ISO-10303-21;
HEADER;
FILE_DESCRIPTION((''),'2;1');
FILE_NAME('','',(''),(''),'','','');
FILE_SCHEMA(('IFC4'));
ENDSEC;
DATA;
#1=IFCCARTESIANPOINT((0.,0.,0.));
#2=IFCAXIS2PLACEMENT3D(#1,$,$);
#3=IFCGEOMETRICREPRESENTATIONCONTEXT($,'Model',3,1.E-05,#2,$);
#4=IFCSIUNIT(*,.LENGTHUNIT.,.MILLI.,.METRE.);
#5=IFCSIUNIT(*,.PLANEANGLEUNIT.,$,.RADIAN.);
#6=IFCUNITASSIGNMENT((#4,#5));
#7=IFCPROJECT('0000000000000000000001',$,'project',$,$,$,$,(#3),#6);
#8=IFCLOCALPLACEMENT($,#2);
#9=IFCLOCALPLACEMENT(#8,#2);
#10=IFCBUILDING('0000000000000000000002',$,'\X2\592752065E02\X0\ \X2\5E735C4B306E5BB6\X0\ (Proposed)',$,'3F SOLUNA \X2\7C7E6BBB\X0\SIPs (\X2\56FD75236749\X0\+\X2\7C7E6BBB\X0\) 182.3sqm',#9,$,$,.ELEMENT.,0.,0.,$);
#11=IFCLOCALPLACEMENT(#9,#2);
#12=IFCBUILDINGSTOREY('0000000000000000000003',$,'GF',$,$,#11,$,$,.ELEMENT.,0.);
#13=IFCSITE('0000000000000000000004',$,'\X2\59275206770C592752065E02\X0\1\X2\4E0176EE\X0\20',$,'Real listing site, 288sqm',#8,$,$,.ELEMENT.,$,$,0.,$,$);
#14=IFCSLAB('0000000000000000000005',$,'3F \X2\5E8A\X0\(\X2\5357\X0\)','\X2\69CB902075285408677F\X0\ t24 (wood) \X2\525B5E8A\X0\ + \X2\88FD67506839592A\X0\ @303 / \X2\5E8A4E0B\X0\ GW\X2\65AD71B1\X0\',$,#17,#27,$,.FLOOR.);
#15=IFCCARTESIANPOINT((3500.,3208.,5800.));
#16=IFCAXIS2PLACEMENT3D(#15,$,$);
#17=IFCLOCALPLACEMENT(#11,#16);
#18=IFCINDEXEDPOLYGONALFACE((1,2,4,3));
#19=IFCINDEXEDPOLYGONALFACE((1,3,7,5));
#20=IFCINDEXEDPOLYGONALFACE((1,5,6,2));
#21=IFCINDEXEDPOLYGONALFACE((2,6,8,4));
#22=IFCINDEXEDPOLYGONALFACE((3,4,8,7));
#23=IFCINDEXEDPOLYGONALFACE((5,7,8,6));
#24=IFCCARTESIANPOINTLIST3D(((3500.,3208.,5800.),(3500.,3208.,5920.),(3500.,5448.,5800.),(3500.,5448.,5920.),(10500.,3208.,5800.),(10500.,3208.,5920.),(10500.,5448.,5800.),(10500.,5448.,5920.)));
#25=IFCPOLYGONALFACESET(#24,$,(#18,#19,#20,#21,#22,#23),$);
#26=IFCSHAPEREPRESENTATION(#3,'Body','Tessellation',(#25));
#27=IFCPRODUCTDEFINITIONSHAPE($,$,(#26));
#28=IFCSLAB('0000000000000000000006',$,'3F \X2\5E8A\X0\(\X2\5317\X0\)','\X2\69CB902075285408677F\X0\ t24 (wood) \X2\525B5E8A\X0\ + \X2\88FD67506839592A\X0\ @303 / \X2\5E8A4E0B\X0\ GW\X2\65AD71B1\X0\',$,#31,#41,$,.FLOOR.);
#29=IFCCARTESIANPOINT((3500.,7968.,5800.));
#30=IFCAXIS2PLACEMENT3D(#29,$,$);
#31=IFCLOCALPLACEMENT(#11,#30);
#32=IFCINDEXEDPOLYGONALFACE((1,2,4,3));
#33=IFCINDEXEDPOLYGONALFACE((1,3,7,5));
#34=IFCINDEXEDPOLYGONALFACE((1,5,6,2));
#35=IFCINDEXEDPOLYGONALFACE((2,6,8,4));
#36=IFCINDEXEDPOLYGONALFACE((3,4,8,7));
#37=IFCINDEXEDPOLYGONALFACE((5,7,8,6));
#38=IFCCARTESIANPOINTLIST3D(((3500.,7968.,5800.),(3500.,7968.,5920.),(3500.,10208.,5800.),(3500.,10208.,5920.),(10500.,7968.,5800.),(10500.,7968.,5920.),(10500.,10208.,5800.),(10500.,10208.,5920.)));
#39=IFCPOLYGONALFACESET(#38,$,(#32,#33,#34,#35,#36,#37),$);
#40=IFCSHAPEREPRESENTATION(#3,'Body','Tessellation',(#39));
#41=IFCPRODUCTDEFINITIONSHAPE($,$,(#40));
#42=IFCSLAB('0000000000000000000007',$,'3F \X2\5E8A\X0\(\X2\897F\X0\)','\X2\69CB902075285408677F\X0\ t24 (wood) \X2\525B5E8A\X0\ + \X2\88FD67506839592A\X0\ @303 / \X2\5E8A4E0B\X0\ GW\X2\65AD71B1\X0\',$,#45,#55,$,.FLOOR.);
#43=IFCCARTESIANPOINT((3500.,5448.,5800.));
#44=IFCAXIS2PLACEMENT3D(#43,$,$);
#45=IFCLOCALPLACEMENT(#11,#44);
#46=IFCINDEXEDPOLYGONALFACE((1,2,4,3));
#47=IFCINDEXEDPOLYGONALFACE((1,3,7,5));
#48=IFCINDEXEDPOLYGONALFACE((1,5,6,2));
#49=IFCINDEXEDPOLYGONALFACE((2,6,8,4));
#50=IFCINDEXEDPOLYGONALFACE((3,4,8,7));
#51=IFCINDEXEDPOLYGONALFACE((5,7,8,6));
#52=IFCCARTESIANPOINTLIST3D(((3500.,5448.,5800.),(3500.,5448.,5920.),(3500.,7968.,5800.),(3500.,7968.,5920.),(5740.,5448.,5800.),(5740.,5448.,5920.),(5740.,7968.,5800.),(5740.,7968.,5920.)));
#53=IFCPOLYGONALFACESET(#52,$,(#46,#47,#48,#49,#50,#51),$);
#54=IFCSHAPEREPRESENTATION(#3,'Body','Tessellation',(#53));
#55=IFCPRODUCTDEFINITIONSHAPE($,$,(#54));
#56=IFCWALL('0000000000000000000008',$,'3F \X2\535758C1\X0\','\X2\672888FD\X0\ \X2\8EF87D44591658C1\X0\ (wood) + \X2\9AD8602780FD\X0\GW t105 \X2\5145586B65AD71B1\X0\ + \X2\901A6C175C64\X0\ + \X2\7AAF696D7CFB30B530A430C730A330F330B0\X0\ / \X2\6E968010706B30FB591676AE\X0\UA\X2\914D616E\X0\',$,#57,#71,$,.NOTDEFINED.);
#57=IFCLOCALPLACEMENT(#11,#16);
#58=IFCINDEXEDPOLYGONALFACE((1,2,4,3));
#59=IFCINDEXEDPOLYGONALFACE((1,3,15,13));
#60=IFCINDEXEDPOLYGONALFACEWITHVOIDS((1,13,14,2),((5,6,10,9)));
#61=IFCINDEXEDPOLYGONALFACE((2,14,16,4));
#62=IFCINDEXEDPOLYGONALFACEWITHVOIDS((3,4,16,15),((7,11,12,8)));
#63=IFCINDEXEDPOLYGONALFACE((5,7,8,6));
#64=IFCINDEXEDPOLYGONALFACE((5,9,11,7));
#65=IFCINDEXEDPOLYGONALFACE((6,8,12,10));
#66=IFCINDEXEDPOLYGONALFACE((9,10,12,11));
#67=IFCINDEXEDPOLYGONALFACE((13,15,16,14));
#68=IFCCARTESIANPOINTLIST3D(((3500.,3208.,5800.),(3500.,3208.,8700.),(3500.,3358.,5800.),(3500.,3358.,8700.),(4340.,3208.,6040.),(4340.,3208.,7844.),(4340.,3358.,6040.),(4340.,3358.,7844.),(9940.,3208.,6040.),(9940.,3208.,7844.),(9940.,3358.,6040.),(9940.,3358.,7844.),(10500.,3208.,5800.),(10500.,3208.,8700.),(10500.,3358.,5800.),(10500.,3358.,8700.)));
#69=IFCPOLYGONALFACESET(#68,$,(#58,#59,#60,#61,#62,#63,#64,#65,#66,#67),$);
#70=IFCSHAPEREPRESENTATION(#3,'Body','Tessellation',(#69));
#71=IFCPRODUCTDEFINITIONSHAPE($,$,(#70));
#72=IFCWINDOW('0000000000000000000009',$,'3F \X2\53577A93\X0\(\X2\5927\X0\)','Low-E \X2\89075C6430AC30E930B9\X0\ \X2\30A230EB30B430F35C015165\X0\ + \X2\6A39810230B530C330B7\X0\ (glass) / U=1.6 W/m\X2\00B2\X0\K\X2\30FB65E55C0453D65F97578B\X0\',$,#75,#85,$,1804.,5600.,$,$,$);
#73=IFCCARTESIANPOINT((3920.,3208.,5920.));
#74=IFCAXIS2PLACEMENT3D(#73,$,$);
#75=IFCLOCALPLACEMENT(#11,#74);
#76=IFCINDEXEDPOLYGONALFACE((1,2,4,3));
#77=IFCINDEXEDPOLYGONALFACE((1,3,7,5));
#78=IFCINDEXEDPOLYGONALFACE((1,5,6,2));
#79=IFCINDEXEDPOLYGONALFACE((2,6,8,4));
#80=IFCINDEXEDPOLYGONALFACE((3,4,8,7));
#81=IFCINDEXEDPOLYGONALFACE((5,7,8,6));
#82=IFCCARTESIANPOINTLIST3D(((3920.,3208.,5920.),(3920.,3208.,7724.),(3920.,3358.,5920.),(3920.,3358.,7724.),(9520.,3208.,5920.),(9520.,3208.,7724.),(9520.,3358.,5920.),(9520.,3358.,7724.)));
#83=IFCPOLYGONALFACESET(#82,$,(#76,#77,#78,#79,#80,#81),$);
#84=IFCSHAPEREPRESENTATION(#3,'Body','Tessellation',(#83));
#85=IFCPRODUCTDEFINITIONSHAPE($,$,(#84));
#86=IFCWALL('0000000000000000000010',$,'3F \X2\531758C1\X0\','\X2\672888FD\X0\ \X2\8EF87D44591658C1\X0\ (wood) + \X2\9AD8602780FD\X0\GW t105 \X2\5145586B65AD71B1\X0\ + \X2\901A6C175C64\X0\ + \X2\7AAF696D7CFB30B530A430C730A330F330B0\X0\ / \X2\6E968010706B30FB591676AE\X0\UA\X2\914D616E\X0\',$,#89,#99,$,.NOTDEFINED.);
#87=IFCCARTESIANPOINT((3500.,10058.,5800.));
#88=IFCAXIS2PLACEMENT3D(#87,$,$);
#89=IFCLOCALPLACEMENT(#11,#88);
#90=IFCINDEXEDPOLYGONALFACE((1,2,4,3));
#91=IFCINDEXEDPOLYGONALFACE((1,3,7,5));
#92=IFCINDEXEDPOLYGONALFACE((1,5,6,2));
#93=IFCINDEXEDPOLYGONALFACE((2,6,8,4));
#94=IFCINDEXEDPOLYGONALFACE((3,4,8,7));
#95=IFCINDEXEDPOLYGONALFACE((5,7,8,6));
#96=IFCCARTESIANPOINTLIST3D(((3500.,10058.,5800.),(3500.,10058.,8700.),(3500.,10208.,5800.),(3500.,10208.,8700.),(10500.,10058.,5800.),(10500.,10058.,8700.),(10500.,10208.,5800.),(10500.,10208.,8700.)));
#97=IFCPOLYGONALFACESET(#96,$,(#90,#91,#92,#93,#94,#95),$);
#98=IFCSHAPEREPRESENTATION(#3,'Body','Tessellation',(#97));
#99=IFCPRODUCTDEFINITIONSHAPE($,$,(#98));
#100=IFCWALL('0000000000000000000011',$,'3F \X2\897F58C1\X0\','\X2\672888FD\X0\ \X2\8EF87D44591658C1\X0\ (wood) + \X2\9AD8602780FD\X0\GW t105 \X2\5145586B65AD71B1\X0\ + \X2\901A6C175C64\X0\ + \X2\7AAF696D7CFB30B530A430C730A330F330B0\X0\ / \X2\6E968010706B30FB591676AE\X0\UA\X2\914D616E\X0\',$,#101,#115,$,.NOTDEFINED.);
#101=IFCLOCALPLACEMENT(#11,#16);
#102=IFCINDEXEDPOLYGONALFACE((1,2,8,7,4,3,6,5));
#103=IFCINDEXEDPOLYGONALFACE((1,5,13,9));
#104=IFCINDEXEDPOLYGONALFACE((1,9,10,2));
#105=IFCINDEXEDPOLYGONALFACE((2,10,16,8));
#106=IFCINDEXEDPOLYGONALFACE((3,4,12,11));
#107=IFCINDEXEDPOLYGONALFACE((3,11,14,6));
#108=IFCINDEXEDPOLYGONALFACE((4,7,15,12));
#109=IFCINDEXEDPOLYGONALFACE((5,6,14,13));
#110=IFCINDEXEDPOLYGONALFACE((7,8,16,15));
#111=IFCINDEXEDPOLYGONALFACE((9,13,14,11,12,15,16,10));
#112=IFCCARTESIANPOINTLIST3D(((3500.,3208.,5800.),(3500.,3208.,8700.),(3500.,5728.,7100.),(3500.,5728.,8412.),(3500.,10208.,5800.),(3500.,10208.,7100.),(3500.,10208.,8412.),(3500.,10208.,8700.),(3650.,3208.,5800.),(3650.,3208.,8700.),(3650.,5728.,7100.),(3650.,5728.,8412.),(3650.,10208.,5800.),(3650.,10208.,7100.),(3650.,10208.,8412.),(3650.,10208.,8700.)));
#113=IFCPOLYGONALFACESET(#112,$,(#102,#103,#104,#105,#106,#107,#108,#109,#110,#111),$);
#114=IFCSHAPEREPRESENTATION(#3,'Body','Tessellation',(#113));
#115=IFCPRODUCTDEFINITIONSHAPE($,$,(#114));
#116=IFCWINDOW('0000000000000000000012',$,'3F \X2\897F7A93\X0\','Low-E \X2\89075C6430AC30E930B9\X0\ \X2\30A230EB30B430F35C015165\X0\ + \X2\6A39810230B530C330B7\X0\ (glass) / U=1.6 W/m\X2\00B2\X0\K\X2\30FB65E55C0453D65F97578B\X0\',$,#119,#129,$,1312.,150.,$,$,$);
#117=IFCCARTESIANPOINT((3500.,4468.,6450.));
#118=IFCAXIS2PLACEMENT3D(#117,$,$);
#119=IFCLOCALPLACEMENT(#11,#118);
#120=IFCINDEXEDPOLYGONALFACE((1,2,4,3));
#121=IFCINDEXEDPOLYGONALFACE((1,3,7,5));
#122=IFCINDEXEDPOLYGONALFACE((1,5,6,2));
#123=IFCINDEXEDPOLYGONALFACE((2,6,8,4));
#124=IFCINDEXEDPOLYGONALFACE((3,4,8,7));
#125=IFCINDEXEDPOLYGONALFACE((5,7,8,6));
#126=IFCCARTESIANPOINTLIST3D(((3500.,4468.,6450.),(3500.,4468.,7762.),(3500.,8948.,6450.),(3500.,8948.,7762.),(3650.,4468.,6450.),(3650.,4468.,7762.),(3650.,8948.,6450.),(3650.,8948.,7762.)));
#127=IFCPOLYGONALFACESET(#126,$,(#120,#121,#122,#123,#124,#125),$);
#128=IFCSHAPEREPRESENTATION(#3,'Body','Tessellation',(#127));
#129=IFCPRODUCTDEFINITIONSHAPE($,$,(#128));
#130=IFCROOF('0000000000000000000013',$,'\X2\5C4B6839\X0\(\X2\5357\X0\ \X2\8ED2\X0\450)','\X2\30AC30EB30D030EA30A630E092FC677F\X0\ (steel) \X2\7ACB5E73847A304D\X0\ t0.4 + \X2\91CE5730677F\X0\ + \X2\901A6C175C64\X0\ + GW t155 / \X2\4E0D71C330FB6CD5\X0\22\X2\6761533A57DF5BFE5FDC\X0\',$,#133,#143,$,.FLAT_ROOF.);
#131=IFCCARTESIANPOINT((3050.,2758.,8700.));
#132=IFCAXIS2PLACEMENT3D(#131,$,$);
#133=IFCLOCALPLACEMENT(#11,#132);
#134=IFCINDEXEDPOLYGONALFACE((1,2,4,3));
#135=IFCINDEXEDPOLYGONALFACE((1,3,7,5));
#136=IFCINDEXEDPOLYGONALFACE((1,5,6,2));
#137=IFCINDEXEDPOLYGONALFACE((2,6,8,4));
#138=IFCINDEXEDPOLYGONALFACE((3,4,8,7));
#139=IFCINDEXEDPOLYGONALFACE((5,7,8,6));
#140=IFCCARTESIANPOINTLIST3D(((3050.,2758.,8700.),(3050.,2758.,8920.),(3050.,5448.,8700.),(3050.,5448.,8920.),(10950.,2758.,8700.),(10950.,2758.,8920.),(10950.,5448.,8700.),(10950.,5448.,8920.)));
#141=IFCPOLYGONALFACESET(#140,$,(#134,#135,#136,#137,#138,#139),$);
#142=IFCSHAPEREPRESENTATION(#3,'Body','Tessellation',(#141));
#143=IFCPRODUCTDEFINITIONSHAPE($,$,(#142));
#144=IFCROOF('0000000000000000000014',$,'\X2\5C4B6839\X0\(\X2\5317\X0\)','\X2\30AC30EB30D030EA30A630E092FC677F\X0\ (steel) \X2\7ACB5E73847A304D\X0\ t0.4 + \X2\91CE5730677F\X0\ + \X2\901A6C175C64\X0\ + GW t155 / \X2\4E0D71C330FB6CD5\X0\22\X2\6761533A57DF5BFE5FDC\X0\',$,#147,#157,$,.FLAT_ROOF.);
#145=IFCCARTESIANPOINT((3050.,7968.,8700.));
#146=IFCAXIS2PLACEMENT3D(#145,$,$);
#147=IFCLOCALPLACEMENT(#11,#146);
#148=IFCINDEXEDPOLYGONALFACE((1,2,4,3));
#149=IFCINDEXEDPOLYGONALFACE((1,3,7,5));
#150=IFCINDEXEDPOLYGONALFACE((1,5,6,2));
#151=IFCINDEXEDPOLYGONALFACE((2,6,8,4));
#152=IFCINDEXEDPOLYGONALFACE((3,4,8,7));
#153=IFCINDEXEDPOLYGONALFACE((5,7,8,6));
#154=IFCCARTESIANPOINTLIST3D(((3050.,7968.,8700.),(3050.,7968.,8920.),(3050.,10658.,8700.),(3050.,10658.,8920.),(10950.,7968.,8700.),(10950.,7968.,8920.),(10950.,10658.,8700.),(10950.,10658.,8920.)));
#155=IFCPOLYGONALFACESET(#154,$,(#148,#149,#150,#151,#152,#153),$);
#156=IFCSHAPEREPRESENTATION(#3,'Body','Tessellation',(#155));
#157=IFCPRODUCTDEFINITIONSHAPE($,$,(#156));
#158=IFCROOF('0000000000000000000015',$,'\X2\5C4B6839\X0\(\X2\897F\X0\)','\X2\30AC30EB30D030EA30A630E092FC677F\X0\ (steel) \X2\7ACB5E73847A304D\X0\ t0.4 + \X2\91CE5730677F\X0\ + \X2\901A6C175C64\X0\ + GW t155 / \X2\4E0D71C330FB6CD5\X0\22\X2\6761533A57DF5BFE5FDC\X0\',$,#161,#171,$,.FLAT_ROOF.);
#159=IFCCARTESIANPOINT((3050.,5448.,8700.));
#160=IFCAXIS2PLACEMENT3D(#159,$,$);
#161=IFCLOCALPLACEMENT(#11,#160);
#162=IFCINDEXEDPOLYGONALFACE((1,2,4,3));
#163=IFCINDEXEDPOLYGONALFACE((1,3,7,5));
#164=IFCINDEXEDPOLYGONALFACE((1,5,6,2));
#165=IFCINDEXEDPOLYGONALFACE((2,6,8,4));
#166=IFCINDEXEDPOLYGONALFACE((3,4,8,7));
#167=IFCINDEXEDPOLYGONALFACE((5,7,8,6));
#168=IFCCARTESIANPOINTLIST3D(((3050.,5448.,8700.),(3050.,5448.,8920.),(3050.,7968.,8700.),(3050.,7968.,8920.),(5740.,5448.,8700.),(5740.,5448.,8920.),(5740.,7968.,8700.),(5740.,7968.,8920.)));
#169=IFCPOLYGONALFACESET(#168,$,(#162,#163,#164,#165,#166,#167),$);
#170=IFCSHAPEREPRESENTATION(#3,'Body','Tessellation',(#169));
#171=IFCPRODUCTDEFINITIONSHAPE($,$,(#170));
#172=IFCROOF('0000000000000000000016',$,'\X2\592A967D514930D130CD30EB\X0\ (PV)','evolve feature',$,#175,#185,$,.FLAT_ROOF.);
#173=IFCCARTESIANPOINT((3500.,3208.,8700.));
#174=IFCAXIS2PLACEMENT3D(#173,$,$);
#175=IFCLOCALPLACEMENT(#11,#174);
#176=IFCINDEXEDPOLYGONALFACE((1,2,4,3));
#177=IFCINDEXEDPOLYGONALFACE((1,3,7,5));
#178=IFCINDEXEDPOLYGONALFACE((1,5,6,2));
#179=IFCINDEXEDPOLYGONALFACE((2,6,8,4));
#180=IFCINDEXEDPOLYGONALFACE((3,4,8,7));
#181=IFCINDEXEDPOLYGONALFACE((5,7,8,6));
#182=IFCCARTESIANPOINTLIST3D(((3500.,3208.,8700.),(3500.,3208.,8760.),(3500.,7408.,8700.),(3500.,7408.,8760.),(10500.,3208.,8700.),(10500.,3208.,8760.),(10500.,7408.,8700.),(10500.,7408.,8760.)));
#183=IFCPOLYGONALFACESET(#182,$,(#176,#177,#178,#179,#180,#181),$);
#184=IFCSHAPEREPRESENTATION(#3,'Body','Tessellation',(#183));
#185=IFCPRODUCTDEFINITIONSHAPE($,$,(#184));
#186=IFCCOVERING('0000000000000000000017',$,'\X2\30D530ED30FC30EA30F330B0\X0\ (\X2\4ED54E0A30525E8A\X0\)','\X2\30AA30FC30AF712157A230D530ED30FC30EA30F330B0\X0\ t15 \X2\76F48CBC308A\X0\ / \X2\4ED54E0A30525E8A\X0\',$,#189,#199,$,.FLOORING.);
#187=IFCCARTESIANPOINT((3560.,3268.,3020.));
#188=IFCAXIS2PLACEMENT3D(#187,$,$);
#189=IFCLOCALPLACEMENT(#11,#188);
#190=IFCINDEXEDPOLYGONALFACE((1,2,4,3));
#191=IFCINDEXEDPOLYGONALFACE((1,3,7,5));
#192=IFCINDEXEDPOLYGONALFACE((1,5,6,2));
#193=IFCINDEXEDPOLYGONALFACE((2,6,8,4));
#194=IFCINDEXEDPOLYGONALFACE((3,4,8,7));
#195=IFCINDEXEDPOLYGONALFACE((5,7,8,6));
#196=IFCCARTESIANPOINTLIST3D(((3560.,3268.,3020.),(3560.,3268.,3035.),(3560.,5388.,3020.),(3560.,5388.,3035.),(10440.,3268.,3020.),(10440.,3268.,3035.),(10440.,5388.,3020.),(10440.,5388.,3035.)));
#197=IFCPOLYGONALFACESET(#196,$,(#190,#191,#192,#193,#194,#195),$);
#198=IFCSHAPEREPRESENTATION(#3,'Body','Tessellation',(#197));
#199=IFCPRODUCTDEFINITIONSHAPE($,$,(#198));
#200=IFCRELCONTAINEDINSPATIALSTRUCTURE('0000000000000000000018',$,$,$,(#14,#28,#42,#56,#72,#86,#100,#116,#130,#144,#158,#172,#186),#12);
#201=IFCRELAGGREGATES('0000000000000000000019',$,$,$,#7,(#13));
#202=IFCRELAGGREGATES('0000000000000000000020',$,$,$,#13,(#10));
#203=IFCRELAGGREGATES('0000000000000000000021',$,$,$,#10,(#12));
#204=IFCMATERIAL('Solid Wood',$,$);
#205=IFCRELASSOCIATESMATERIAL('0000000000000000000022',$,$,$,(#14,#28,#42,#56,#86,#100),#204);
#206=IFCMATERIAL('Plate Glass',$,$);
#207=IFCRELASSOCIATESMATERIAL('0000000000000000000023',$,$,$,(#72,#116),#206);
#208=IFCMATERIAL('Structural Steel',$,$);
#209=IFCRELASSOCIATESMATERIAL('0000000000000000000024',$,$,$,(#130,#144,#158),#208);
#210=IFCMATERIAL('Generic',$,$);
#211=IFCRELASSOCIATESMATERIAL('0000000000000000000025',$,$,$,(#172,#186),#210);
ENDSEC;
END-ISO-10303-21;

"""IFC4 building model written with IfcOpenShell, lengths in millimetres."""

from ifc_helpers import new_model, si_unit, frame, frame_2d, origin, place, context, project, spatial, rectangle, extrude, material, element, fill, save


model = new_model("IFC4")

# Units and contexts
model_context = context("Model", 3, precision=1e-05, world=origin())
ifc_project = project(units=[si_unit("LENGTHUNIT", "METRE", prefix="MILLI"), si_unit("PLANEANGLEUNIT", "RADIAN")], contexts=[model_context])

# Site, building, storey
site_placement = place(None, origin())
site = spatial("IfcSite", under=ifc_project, at=site_placement, Name="大分県大分市1丁目20", ObjectType="Real listing site, 288sqm", CompositionType="ELEMENT", RefElevation=0.0)
building_placement = place(site_placement, origin())
building = spatial("IfcBuilding", under=site, at=building_placement, Name="大分市 平屋の家 (Proposed)", ObjectType="3F SOLUNA 籾殻SIPs (国産杉+籾殻) 182.3sqm", CompositionType="ELEMENT", ElevationOfRefHeight=0.0, ElevationOfTerrain=0.0)
storey_placement = place(building_placement, origin())
storey = spatial("IfcBuildingStorey", under=building, at=storey_placement, Name="GF", CompositionType="ELEMENT", Elevation=0.0)

# Slabs
ifc_material_1 = material(Name="Solid Wood")
slab_1_placement = place(storey_placement, frame((3500.0, 3208.0, 5800.0)))
element("IfcSlab", 1, at=slab_1_placement, inside=storey, material=ifc_material_1, Name="3F 床(南)", Description="構造用合板 t24 (wood) 剛床 + 製材根太 @303 / 床下 GW断熱", PredefinedType="FLOOR", context=model_context, shape_type="SweptSolid", body=[
    extrude(rectangle(XDim=7000.0, YDim=2240.0, at=frame_2d((3500.0, 1120.0))), frame((3500.0, 3208.0, 5800.0)), (0.0, 0.0, 1.0), 120.0),
])
slab_2_placement = place(storey_placement, frame((3500.0, 7968.0, 5800.0)))
element("IfcSlab", 2, at=slab_2_placement, inside=storey, material=ifc_material_1, Name="3F 床(北)", Description="構造用合板 t24 (wood) 剛床 + 製材根太 @303 / 床下 GW断熱", PredefinedType="FLOOR", context=model_context, shape_type="SweptSolid", body=[
    extrude(rectangle(XDim=7000.0, YDim=2240.0, at=frame_2d((3500.0, 1120.0))), frame((3500.0, 7968.0, 5800.0)), (0.0, 0.0, 1.0), 120.0),
])
slab_3_placement = place(storey_placement, frame((3500.0, 5448.0, 5800.0)))
element("IfcSlab", 3, at=slab_3_placement, inside=storey, material=ifc_material_1, Name="3F 床(西)", Description="構造用合板 t24 (wood) 剛床 + 製材根太 @303 / 床下 GW断熱", PredefinedType="FLOOR", context=model_context, shape_type="SweptSolid", body=[
    extrude(rectangle(XDim=2240.0, YDim=2520.0, at=frame_2d((1120.0, 1260.0))), frame((3500.0, 5448.0, 5800.0)), (0.0, 0.0, 1.0), 120.0),
])

# Wall, opening, window
wall_1_placement = place(storey_placement, frame((3500.0, 3208.0, 5800.0)))
wall_1 = element("IfcWall", 4, at=wall_1_placement, inside=storey, material=ifc_material_1, Name="3F 南壁", Description="木製 軸組外壁 (wood) + 高性能GW t105 充填断熱 + 通気層 + 窯業系サイディング / 準耐火・外皮UA配慮", PredefinedType="NOTDEFINED", context=model_context, shape_type="SweptSolid", body=[
    extrude(rectangle(XDim=7000.0, YDim=150.0, at=frame_2d((3500.0, 75.0))), frame((3500.0, 3208.0, 5800.0)), (0.0, 0.0, 1.0), 2900.0),
])
opening_1_placement = place(storey_placement, frame((3920.0, 3208.0, 5920.0)))
opening_1 = element("IfcOpeningElement", 5, at=opening_1_placement, cuts=wall_1, PredefinedType="NOTDEFINED", context=model_context, shape_type="SweptSolid", body=[
    extrude(rectangle(XDim=5600.0, YDim=150.0, at=frame_2d((2800.0, 75.0))), frame((3920.0, 3208.0, 5920.0)), (0.0, 0.0, 1.0), 1804.0),
])
ifc_material_2 = material(Name="Plate Glass")
window_1_placement = place(storey_placement, frame((3920.0, 3208.0, 5920.0)))
window_1 = element("IfcWindow", 6, at=window_1_placement, inside=storey, material=ifc_material_2, Name="3F 南窓(大)", Description="Low-E 複層ガラス アルゴン封入 + 樹脂サッシ (glass) / U=1.6 W/m²K・日射取得型", OverallHeight=1804.0, OverallWidth=5600.0, context=model_context, shape_type="SweptSolid", body=[
    extrude(rectangle(XDim=5600.0, YDim=150.0, at=frame_2d((2800.0, 75.0))), frame((3920.0, 3208.0, 5920.0)), (0.0, 0.0, 1.0), 1804.0),
])
fill(opening_1, window_1)

# Wall
wall_2_placement = place(storey_placement, frame((3500.0, 10058.0, 5800.0)))
element("IfcWall", 7, at=wall_2_placement, inside=storey, material=ifc_material_1, Name="3F 北壁", Description="木製 軸組外壁 (wood) + 高性能GW t105 充填断熱 + 通気層 + 窯業系サイディング / 準耐火・外皮UA配慮", PredefinedType="NOTDEFINED", context=model_context, shape_type="SweptSolid", body=[
    extrude(rectangle(XDim=7000.0, YDim=150.0, at=frame_2d((3500.0, 75.0))), frame((3500.0, 10058.0, 5800.0)), (0.0, 0.0, 1.0), 2900.0),
])

# Wall, opening, window
wall_3_placement = place(storey_placement, frame((3500.0, 3208.0, 5800.0)))
wall_3 = element("IfcWall", 8, at=wall_3_placement, inside=storey, material=ifc_material_1, Name="3F 西壁", Description="木製 軸組外壁 (wood) + 高性能GW t105 充填断熱 + 通気層 + 窯業系サイディング / 準耐火・外皮UA配慮", PredefinedType="NOTDEFINED", context=model_context, shape_type="SweptSolid", body=[
    extrude(rectangle(XDim=150.0, YDim=7000.0, at=frame_2d((75.0, 3500.0))), frame((3500.0, 3208.0, 5800.0)), (0.0, 0.0, 1.0), 2900.0),
])
opening_2_placement = place(storey_placement, frame((3500.0, 4468.0, 6450.0)))
opening_2 = element("IfcOpeningElement", 9, at=opening_2_placement, cuts=wall_3, PredefinedType="NOTDEFINED", context=model_context, shape_type="SweptSolid", body=[
    extrude(rectangle(XDim=150.0, YDim=4480.0, at=frame_2d((75.0, 2240.0))), frame((3500.0, 4468.0, 6450.0)), (0.0, 0.0, 1.0), 1312.0),
])
window_2_placement = place(storey_placement, frame((3500.0, 4468.0, 6450.0)))
window_2 = element("IfcWindow", 10, at=window_2_placement, inside=storey, material=ifc_material_2, Name="3F 西窓", Description="Low-E 複層ガラス アルゴン封入 + 樹脂サッシ (glass) / U=1.6 W/m²K・日射取得型", OverallHeight=1312.0, OverallWidth=150.0, context=model_context, shape_type="SweptSolid", body=[
    extrude(rectangle(XDim=150.0, YDim=4480.0, at=frame_2d((75.0, 2240.0))), frame((3500.0, 4468.0, 6450.0)), (0.0, 0.0, 1.0), 1312.0),
])
fill(opening_2, window_2)

# Roofs
ifc_material_3 = material(Name="Structural Steel")
roof_1_placement = place(storey_placement, frame((3050.0, 2758.0, 8700.0)))
element("IfcRoof", 11, at=roof_1_placement, inside=storey, material=ifc_material_3, Name="屋根(南 軒450)", Description="ガルバリウム鋼板 (steel) 立平葺き t0.4 + 野地板 + 通気層 + GW t155 / 不燃・法22条区域対応", PredefinedType="FLAT_ROOF", context=model_context, shape_type="SweptSolid", body=[
    extrude(rectangle(XDim=7900.0, YDim=2690.0, at=frame_2d((3950.0, 1345.0))), frame((3050.0, 2758.0, 8700.0)), (0.0, 0.0, 1.0), 220.0),
])
roof_2_placement = place(storey_placement, frame((3050.0, 7968.0, 8700.0)))
element("IfcRoof", 12, at=roof_2_placement, inside=storey, material=ifc_material_3, Name="屋根(北)", Description="ガルバリウム鋼板 (steel) 立平葺き t0.4 + 野地板 + 通気層 + GW t155 / 不燃・法22条区域対応", PredefinedType="FLAT_ROOF", context=model_context, shape_type="SweptSolid", body=[
    extrude(rectangle(XDim=7900.0, YDim=2690.0, at=frame_2d((3950.0, 1345.0))), frame((3050.0, 7968.0, 8700.0)), (0.0, 0.0, 1.0), 220.0),
])
roof_3_placement = place(storey_placement, frame((3050.0, 5448.0, 8700.0)))
element("IfcRoof", 13, at=roof_3_placement, inside=storey, material=ifc_material_3, Name="屋根(西)", Description="ガルバリウム鋼板 (steel) 立平葺き t0.4 + 野地板 + 通気層 + GW t155 / 不燃・法22条区域対応", PredefinedType="FLAT_ROOF", context=model_context, shape_type="SweptSolid", body=[
    extrude(rectangle(XDim=2690.0, YDim=2520.0, at=frame_2d((1345.0, 1260.0))), frame((3050.0, 5448.0, 8700.0)), (0.0, 0.0, 1.0), 220.0),
])
ifc_material_4 = material(Name="Generic")
roof_4_placement = place(storey_placement, frame((3500.0, 3208.0, 8700.0)))
element("IfcRoof", 14, at=roof_4_placement, inside=storey, material=ifc_material_4, Name="太陽光パネル (PV)", Description="evolve feature", PredefinedType="FLAT_ROOF", context=model_context, shape_type="SweptSolid", body=[
    extrude(rectangle(XDim=7000.0, YDim=4200.0, at=frame_2d((3500.0, 2100.0))), frame((3500.0, 3208.0, 8700.0)), (0.0, 0.0, 1.0), 60.0),
])

# Covering
covering_1_placement = place(storey_placement, frame((3560.0, 3268.0, 3020.0)))
element("IfcCovering", 15, at=covering_1_placement, inside=storey, material=ifc_material_4, Name="フローリング (仕上げ床)", Description="オーク無垢フローリング t15 直貼り / 仕上げ床", PredefinedType="FLOORING", context=model_context, shape_type="SweptSolid", body=[
    extrude(rectangle(XDim=6880.0, YDim=2120.0, at=frame_2d((3440.0, 1060.0))), frame((3560.0, 3268.0, 3020.0)), (0.0, 0.0, 1.0), 15.0),
])

save(model, "model.ifc")
